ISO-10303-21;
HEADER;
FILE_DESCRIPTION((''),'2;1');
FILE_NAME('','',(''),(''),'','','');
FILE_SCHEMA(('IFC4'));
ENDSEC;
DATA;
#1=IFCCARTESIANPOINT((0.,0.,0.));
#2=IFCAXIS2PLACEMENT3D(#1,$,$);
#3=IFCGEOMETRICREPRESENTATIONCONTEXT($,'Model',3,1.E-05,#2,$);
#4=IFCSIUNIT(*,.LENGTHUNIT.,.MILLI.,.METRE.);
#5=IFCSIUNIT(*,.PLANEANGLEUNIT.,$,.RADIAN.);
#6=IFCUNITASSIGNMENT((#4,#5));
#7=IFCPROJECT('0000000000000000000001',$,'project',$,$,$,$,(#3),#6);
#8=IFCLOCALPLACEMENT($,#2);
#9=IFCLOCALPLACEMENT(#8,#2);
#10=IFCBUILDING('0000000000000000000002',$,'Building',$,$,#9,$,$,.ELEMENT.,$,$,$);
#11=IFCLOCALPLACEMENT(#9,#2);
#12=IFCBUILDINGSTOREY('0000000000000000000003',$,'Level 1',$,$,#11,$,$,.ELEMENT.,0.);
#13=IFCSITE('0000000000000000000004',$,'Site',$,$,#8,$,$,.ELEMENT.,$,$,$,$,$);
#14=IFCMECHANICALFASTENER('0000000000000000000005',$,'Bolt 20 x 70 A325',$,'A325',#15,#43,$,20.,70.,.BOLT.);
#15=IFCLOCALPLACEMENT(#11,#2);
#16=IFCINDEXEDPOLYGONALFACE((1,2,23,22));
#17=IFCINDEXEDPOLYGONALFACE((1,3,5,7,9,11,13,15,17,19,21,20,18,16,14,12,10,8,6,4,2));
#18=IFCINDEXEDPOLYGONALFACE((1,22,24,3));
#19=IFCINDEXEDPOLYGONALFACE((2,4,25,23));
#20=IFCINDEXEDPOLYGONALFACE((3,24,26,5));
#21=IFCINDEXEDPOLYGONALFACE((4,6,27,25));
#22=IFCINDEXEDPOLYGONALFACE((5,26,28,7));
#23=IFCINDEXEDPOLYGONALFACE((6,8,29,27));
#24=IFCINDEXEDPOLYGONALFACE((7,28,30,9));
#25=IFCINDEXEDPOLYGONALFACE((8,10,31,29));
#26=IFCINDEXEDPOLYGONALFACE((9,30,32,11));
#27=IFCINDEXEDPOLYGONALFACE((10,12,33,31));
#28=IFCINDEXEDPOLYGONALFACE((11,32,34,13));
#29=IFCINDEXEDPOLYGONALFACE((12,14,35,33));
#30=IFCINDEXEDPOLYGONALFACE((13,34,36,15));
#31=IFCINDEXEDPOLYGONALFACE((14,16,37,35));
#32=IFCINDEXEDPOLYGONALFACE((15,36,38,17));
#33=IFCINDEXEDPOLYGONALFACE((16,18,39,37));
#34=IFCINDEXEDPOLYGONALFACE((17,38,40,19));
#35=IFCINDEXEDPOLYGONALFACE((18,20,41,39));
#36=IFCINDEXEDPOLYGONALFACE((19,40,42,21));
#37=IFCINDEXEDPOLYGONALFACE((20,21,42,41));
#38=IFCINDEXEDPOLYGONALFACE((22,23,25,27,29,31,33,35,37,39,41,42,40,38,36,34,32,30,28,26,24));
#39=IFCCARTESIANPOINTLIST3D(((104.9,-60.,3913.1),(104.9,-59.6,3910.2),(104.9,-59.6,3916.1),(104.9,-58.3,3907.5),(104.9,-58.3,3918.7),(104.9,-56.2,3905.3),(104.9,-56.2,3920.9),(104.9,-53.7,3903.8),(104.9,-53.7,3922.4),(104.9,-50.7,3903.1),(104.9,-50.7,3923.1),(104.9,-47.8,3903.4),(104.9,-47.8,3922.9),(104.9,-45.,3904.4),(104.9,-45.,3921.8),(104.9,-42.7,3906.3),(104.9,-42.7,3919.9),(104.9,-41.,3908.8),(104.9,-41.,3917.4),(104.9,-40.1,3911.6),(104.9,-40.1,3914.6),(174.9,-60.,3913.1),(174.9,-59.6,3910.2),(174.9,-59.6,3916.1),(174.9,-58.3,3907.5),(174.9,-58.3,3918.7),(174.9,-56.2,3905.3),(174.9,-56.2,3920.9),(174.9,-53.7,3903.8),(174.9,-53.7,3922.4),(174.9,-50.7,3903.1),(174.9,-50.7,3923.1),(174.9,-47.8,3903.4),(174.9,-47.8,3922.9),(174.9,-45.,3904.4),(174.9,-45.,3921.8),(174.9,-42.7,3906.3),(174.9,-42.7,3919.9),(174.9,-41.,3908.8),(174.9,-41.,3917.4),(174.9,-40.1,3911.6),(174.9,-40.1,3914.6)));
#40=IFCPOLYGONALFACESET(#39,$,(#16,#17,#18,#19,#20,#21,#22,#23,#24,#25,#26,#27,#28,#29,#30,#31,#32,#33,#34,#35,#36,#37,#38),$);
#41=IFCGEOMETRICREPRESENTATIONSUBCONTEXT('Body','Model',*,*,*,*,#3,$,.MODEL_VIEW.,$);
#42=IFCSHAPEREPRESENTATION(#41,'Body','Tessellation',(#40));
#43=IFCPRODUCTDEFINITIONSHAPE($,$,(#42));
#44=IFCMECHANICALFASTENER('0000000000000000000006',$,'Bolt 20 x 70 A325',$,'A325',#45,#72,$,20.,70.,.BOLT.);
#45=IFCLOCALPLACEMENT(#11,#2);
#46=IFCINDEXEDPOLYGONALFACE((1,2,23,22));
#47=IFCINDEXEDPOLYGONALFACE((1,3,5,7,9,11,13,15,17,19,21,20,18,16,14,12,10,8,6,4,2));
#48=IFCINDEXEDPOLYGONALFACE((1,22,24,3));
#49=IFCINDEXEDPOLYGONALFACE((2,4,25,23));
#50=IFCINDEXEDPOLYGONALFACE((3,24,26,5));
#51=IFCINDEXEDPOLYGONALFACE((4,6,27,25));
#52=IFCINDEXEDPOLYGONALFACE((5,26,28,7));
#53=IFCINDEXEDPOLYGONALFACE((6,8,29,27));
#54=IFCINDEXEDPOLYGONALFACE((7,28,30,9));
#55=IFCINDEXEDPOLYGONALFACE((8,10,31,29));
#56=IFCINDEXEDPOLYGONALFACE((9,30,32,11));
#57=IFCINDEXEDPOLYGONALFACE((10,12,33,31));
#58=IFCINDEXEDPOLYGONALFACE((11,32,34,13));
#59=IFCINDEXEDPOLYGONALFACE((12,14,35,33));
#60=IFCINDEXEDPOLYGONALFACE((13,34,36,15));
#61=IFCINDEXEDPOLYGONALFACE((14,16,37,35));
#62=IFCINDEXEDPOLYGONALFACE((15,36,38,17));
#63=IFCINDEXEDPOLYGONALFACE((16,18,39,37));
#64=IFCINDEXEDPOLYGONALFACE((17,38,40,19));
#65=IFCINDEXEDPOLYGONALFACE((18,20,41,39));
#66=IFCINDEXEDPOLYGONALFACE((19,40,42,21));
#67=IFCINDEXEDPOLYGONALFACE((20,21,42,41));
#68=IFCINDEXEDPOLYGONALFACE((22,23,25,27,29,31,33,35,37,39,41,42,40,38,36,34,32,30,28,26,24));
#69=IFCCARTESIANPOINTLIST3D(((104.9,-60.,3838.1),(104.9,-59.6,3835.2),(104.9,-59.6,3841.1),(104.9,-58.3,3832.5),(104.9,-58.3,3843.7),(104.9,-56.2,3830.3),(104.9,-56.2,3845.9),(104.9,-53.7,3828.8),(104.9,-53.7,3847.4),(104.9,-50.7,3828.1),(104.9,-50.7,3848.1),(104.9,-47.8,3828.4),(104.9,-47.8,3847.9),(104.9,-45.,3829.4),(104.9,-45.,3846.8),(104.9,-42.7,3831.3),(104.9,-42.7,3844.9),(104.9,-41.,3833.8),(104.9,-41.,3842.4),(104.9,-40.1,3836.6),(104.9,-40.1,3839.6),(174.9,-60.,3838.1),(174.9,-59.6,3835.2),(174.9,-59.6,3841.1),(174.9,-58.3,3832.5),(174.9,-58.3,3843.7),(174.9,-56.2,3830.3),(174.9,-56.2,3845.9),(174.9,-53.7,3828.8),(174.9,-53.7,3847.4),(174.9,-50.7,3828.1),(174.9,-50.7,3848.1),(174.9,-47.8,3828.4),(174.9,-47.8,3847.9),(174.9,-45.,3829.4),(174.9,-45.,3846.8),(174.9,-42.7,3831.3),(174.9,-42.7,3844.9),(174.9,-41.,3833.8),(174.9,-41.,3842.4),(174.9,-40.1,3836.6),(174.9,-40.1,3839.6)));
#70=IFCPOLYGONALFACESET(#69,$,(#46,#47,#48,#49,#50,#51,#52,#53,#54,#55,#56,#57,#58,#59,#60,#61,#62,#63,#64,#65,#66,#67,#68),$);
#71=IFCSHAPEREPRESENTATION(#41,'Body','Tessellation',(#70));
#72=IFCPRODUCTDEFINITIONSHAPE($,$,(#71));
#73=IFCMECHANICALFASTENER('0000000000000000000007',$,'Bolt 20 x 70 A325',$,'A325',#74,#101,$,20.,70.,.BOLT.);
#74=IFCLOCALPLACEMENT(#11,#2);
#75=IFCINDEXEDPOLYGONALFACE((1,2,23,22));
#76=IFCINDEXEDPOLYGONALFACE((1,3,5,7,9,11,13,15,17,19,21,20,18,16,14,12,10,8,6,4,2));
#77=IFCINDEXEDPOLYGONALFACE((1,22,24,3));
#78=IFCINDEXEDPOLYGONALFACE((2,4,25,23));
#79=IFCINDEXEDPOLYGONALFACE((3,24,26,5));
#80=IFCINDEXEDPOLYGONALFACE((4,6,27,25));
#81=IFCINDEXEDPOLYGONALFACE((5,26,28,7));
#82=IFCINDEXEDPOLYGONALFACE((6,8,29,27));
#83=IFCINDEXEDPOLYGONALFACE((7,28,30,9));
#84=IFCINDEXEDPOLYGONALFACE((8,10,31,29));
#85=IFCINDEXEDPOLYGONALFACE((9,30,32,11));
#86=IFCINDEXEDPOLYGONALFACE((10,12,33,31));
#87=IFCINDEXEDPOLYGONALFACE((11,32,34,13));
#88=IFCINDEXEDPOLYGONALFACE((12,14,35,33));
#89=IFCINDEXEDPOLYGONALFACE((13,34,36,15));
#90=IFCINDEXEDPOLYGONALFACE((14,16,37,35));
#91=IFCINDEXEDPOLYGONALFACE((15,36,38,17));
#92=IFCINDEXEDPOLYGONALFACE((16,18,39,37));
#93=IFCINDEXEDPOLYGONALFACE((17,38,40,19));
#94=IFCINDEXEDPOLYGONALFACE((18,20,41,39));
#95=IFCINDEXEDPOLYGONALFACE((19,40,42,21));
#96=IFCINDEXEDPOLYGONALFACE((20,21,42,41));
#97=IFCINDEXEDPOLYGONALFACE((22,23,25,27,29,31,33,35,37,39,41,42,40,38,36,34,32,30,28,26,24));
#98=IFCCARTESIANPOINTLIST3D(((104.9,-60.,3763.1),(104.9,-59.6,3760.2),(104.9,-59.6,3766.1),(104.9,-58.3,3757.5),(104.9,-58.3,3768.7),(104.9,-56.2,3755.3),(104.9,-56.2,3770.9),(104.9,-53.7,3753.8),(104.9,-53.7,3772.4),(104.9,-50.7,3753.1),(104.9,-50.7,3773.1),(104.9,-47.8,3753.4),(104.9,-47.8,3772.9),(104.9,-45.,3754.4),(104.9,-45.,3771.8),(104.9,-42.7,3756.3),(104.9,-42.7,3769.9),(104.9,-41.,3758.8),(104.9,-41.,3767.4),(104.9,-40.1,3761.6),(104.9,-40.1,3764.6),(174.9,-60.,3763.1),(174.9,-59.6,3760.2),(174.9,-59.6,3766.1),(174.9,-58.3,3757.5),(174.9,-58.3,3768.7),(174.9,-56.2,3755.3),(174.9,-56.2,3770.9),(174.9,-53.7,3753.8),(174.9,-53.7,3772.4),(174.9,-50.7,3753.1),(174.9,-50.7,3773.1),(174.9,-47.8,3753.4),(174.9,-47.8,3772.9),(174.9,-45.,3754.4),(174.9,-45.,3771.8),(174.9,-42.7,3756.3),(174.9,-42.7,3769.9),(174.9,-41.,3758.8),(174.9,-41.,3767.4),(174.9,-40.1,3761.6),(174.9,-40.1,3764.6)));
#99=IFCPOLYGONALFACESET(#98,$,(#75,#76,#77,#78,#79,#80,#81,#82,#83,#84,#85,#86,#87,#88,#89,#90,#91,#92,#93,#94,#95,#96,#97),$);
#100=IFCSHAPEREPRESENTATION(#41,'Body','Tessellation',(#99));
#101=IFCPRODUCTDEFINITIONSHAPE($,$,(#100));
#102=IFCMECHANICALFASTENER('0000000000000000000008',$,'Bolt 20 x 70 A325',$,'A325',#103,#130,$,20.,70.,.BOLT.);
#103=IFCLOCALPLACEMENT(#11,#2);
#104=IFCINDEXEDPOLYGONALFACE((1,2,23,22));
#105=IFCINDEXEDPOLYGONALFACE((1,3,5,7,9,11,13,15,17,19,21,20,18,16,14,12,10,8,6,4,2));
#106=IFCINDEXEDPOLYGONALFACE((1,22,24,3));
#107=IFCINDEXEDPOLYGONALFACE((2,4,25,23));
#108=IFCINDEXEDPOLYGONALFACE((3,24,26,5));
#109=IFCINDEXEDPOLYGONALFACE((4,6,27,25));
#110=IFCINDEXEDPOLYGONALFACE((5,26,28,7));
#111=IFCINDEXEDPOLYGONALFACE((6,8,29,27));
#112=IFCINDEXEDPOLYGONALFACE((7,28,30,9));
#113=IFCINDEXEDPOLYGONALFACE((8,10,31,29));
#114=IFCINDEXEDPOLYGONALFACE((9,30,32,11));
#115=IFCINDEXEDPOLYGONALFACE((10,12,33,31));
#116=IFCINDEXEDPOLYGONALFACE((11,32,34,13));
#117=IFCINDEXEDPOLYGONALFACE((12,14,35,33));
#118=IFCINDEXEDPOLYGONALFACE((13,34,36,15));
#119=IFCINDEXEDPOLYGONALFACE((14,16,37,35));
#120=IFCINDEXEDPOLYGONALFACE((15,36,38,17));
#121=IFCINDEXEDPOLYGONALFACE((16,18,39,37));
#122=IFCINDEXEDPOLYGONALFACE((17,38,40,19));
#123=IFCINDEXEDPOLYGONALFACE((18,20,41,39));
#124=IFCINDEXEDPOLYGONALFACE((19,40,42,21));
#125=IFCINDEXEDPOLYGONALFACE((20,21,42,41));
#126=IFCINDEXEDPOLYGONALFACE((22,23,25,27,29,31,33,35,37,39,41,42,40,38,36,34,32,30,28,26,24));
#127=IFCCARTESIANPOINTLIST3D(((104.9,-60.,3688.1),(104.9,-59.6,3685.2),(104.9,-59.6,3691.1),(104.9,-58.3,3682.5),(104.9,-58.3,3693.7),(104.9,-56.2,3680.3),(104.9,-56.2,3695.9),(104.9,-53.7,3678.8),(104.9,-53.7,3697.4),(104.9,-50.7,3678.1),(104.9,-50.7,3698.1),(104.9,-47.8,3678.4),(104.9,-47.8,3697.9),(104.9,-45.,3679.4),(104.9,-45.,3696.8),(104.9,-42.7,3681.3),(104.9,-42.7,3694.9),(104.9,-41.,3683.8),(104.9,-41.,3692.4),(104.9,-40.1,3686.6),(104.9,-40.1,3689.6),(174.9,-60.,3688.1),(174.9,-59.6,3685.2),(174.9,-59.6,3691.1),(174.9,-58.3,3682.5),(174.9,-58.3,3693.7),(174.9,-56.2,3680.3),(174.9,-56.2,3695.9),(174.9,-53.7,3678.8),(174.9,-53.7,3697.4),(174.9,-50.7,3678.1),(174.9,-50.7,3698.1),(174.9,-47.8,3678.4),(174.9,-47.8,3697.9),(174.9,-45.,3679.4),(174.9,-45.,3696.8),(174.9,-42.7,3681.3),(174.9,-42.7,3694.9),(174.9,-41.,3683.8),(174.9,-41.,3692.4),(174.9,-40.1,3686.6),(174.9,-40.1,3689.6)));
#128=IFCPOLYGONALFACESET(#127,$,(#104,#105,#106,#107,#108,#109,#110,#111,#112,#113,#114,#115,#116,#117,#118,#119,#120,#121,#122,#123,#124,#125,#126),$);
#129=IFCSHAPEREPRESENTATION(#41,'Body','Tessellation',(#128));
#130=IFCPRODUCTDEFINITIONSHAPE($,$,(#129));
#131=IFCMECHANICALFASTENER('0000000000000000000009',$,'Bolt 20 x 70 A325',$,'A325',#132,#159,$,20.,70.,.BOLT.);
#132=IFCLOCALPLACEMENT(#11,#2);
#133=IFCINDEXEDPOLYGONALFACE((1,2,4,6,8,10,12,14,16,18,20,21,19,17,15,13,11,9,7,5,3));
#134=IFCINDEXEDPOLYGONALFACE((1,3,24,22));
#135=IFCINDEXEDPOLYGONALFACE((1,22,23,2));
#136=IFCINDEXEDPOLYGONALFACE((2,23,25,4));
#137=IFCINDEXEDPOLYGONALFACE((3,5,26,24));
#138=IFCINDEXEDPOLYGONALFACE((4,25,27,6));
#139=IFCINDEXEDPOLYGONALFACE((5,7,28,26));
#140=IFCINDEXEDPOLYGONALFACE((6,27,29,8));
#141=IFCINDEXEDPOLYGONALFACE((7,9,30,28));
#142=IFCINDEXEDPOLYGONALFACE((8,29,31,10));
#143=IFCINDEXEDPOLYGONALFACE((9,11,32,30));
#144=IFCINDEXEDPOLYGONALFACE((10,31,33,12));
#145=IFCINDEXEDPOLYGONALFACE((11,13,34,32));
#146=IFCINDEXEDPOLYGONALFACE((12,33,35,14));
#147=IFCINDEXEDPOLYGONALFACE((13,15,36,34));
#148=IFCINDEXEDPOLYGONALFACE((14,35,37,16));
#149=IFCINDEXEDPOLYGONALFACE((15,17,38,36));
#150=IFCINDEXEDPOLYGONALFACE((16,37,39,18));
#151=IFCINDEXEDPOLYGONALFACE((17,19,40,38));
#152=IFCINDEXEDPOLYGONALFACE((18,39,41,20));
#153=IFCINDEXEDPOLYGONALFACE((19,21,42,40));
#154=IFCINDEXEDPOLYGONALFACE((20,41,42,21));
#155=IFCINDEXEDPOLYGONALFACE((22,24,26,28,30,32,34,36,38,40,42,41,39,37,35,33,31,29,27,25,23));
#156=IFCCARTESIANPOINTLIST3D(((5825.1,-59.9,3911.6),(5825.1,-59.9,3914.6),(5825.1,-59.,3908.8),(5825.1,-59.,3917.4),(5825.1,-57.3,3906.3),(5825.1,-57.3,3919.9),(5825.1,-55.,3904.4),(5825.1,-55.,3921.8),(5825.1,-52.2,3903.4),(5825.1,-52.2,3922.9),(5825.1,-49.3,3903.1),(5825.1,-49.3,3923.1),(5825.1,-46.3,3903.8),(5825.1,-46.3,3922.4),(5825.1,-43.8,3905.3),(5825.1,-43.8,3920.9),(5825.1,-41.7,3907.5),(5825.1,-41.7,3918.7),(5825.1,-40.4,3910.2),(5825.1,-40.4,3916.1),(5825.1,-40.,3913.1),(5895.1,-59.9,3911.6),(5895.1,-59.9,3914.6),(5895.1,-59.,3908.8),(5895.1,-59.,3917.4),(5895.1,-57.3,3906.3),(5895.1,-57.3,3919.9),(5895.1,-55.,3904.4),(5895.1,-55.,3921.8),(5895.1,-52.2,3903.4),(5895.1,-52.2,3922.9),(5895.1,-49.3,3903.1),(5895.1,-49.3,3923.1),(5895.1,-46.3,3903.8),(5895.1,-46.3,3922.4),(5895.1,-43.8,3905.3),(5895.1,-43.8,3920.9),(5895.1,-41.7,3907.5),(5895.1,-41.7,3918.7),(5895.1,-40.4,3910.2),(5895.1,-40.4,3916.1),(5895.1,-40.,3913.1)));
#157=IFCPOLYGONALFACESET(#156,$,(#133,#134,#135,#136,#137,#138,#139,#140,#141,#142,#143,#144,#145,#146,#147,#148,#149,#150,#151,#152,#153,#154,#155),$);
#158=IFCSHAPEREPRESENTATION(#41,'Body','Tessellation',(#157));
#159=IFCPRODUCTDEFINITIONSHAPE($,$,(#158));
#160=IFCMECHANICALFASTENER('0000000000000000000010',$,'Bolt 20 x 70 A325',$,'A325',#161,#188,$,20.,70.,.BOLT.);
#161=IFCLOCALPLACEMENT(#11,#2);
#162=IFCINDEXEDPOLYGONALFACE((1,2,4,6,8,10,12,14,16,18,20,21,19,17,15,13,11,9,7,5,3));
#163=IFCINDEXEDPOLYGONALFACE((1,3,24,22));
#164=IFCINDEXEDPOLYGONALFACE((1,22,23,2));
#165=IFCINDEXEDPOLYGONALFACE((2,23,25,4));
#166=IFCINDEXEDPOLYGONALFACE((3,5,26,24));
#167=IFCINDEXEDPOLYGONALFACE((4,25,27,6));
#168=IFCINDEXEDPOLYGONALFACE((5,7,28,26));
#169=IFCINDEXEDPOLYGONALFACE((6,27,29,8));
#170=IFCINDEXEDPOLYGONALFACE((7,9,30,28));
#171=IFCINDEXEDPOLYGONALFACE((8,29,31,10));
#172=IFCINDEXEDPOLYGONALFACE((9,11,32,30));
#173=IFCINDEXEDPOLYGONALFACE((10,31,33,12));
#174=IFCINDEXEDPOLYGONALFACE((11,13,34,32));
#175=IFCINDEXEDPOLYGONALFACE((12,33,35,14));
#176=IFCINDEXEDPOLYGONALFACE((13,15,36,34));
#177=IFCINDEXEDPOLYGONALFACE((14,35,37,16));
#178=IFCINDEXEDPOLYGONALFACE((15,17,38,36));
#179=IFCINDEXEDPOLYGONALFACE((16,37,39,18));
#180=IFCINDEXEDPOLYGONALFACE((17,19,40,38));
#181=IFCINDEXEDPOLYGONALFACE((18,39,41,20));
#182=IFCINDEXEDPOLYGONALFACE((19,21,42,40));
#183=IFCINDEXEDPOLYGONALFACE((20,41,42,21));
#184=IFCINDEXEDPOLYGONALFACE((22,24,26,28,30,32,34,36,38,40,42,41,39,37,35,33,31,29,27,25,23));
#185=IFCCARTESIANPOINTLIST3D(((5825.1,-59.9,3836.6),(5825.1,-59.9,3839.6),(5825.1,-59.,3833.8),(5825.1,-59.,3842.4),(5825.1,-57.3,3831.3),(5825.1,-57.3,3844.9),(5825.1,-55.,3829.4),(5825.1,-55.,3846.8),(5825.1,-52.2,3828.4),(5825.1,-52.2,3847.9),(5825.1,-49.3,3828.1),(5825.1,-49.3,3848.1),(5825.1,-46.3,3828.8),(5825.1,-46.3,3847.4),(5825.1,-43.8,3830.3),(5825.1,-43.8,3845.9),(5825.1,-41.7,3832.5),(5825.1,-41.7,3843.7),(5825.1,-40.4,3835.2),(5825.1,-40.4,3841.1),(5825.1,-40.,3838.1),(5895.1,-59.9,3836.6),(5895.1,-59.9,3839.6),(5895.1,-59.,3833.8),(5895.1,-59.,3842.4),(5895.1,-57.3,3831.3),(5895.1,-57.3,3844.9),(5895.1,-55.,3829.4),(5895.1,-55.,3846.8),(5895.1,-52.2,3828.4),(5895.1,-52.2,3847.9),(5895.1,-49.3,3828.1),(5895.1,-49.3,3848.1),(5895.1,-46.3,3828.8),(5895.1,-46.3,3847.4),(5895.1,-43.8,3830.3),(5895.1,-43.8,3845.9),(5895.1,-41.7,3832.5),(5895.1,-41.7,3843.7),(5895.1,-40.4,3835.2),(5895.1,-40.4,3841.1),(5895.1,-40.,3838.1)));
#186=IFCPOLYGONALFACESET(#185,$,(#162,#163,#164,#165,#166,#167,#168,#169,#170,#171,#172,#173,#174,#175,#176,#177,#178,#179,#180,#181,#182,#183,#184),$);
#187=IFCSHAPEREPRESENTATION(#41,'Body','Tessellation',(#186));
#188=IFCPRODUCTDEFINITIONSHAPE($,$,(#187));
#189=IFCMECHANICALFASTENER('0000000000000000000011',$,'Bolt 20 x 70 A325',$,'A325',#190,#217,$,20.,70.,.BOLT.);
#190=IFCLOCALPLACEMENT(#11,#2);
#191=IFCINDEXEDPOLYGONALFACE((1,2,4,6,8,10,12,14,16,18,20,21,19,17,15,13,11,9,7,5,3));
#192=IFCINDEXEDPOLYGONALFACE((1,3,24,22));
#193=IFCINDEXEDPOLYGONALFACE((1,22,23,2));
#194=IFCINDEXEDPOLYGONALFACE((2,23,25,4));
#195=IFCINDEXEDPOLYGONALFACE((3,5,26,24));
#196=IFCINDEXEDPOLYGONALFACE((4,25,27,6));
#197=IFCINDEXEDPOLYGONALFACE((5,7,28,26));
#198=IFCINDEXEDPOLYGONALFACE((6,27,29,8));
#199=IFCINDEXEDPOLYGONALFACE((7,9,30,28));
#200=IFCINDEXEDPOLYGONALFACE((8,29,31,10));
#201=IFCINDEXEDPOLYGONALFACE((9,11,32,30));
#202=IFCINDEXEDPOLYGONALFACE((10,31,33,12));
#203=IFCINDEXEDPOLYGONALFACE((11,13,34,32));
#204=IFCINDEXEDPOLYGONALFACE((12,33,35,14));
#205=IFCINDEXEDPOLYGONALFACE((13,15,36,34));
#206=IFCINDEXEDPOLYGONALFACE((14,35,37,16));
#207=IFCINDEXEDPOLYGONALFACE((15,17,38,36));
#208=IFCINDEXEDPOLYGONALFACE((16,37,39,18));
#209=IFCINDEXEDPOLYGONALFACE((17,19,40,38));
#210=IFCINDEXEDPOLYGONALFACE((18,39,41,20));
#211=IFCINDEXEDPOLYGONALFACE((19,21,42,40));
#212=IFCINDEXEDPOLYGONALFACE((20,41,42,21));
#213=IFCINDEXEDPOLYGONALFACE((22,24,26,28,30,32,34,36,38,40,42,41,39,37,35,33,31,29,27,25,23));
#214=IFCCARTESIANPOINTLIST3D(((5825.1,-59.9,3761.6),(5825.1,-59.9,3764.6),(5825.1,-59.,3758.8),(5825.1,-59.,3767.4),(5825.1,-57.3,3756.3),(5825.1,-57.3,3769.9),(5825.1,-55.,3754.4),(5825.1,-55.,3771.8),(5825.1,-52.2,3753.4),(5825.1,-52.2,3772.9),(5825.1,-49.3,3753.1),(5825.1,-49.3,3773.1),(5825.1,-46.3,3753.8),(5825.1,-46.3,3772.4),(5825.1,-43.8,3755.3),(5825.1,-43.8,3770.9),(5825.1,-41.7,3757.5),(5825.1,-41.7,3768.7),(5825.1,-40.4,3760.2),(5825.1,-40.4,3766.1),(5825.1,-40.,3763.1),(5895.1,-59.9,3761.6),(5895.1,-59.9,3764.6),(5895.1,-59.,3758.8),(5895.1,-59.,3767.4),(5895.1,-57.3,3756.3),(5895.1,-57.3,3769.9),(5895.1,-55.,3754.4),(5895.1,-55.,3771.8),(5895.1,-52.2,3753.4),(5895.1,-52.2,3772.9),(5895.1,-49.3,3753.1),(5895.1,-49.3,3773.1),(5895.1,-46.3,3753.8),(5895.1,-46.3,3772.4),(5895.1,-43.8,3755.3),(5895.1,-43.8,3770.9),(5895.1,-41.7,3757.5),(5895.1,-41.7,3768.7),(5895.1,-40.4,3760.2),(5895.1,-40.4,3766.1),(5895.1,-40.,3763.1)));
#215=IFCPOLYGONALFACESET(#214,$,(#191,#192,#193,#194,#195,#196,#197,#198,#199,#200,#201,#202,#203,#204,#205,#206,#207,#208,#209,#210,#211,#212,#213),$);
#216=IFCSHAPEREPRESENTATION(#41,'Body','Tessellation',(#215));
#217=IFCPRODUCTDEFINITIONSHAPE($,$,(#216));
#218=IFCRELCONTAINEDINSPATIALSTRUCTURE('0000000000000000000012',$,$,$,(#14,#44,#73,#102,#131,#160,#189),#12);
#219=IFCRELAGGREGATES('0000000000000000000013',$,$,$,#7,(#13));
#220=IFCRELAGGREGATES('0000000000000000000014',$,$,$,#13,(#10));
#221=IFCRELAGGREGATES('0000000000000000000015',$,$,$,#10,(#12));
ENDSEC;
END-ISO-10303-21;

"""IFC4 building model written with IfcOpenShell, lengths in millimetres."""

from ifc_helpers import new_model, si_unit, frame, origin, origin_2d, place, context, subcontext, project, spatial, circle, extrude, element, save


model = new_model("IFC4")

# Units and contexts
model_context = context("Model", 3, precision=1e-05, world=origin())
body_context = subcontext(model_context, "Body", "Model", "MODEL_VIEW")
ifc_project = project(units=[si_unit("LENGTHUNIT", "METRE", prefix="MILLI"), si_unit("PLANEANGLEUNIT", "RADIAN")], contexts=[model_context])

# Site, building, storey
site_placement = place(None, origin())
site = spatial("IfcSite", under=ifc_project, at=site_placement, Name="Site", CompositionType="ELEMENT")
building_placement = place(site_placement, origin())
building = spatial("IfcBuilding", under=site, at=building_placement, Name="Building", CompositionType="ELEMENT")
storey_placement = place(building_placement, origin())
storey = spatial("IfcBuildingStorey", under=building, at=storey_placement, Name="Level 1", CompositionType="ELEMENT", Elevation=0.0)

# Mechanical fasteners
for number, where, z_axis, x_axis, name in (
    (1, (174.9, -50.0, 3913.1), (-1.0, 0.0, 0.0), (0.0, -1.0, 0.0), "Bolt 20 x 70 A325"),
    (2, (174.9, -50.0, 3838.1), (-1.0, 0.0, 0.0), (0.0, -1.0, 0.0), "Bolt 20 x 70 A325"),
    (3, (174.9, -50.0, 3763.1), (-1.0, 0.0, 0.0), (0.0, -1.0, 0.0), "Bolt 20 x 70 A325"),
    (4, (174.9, -50.0, 3688.1), (-1.0, 0.0, 0.0), (0.0, -1.0, 0.0), "Bolt 20 x 70 A325"),
    (5, (5825.1, -50.0, 3913.1), (1.0, 0.0, 0.0), (0.0, 1.0, 0.0), "Bolt 20 x 70 A325"),
    (6, (5825.1, -50.0, 3838.1), (1.0, 0.0, 0.0), (0.0, 1.0, 0.0), "Bolt 20 x 70 A325"),
    (7, (5825.1, -50.0, 3763.1), (1.0, 0.0, 0.0), (0.0, 1.0, 0.0), "Bolt 20 x 70 A325"),
):
    element("IfcMechanicalFastener", number, at=place(storey_placement, frame(where, z_axis=z_axis, x_axis=x_axis)), inside=storey, Name=name, ObjectType="A325", NominalDiameter=20.0, NominalLength=70.0, PredefinedType="BOLT", context=body_context, shape_type="SweptSolid", body=[
        extrude(circle(Radius=10.0, at=origin_2d()), origin(), (0.0, 0.0, 1.0), 70.0),
    ])

save(model, "model.ifc")
